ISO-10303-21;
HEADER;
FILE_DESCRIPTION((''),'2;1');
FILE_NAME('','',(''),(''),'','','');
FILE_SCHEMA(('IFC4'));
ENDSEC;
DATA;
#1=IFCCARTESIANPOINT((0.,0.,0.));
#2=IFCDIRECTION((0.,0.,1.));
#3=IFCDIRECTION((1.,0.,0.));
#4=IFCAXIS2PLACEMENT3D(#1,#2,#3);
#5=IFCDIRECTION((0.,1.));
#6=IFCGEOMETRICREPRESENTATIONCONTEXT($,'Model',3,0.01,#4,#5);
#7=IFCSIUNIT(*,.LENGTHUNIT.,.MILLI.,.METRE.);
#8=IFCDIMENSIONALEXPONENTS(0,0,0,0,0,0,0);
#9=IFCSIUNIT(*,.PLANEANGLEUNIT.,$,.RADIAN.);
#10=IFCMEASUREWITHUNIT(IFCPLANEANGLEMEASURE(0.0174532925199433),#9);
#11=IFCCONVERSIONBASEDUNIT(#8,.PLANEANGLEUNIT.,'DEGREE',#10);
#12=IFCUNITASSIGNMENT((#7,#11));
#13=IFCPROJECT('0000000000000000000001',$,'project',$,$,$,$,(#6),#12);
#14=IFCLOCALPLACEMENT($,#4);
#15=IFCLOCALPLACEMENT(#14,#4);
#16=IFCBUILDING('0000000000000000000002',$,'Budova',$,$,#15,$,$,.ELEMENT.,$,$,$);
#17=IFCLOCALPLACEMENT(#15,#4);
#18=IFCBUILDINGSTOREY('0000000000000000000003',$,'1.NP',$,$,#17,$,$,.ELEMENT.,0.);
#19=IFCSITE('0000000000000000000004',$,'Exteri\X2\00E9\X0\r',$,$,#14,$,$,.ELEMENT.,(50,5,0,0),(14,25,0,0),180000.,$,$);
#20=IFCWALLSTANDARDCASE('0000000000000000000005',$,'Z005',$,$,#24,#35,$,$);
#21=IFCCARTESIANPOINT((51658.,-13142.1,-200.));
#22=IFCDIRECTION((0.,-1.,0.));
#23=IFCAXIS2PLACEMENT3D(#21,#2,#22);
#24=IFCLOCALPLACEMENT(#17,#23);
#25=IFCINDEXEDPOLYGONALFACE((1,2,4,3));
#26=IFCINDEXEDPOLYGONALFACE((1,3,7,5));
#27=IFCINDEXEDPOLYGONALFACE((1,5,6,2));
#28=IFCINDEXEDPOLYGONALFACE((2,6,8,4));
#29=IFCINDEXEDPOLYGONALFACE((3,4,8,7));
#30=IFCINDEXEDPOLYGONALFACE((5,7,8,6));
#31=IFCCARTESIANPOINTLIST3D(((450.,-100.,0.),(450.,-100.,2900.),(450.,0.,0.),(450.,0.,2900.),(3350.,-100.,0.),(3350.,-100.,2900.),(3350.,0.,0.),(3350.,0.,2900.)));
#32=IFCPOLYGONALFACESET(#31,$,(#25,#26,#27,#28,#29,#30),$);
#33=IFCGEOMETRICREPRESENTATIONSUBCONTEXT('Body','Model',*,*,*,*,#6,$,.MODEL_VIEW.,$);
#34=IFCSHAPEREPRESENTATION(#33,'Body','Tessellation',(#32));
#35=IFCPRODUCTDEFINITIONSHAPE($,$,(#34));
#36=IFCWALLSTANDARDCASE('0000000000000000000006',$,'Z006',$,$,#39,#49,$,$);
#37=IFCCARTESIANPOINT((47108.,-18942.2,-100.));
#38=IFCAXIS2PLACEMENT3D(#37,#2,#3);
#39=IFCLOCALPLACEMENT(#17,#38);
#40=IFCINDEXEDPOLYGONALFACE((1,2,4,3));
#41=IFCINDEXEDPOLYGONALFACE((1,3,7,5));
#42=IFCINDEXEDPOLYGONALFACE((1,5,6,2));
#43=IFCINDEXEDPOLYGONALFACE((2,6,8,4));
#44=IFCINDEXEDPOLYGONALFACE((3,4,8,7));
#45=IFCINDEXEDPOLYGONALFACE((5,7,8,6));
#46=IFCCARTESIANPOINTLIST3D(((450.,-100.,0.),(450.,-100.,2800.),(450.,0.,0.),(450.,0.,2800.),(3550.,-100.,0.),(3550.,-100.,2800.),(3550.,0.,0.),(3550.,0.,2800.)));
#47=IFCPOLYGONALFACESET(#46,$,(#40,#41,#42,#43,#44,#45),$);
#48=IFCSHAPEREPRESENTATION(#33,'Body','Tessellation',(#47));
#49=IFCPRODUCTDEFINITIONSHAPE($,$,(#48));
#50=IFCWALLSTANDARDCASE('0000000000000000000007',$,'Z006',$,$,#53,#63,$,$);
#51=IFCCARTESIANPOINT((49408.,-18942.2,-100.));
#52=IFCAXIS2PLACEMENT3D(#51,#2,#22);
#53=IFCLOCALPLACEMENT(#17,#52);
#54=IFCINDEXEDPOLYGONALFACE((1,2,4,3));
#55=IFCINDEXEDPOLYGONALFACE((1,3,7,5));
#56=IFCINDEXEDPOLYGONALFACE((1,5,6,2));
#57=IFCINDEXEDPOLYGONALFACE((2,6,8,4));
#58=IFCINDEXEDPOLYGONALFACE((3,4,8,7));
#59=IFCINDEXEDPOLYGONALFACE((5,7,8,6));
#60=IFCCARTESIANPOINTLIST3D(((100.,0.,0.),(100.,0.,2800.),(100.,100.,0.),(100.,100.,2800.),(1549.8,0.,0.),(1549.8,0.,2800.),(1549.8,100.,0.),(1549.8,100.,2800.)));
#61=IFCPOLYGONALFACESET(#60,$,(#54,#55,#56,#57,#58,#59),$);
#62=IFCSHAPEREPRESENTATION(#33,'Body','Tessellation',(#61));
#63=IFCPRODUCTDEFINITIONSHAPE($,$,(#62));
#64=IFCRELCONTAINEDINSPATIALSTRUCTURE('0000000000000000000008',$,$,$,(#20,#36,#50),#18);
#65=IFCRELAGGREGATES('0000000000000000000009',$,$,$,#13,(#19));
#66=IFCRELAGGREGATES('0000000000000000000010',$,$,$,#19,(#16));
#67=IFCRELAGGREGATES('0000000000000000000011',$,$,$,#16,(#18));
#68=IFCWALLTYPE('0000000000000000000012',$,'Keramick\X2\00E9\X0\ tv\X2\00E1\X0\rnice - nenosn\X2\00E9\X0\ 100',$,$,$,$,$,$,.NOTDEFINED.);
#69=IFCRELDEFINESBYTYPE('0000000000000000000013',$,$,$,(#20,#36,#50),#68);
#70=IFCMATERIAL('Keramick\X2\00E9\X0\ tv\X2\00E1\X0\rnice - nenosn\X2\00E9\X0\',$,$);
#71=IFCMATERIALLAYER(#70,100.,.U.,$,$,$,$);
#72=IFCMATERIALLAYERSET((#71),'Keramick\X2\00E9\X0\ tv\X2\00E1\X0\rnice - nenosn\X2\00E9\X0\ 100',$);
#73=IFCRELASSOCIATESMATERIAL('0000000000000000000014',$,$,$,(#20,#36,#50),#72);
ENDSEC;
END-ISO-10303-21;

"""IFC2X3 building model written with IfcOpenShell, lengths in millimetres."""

from ifc_helpers import new_model, entity, si_unit, converted_unit, direction, frame, origin_with_axes, place, context, subcontext, project, spatial, polyline, outline, extrude, material, layer, layer_set, layer_usage, type_object, element, save


model = new_model("IFC2X3")

# Units and contexts
model_context = context("Model", 3, precision=0.01, world=origin_with_axes(), true_north=direction((0.0, 1.0)))
body_context = subcontext(model_context, "Body", "Model", "MODEL_VIEW")
ifc_project = project(units=[si_unit("LENGTHUNIT", "METRE", prefix="MILLI"), converted_unit("PLANEANGLEUNIT", "DEGREE", entity("IfcPlaneAngleMeasure", 0.0174532925199433), si_unit("PLANEANGLEUNIT", "RADIAN"), dimensions=[0, 0, 0, 0, 0, 0, 0])], contexts=[model_context])

# Site, building, storey
site_placement = place(None, origin_with_axes())
site = spatial("IfcSite", under=ifc_project, at=site_placement, Name="Exteriér", CompositionType="ELEMENT", RefLatitude=(50, 5, 0, 0), RefLongitude=(14, 25, 0, 0), RefElevation=180000.0)
building_placement = place(site_placement, origin_with_axes())
building = spatial("IfcBuilding", under=site, at=building_placement, Name="Budova", CompositionType="ELEMENT")
storey_placement = place(building_placement, origin_with_axes())
storey = spatial("IfcBuildingStorey", under=building, at=storey_placement, Name="1.NP", CompositionType="ELEMENT", Elevation=0.0)

# Wall
ifc_material_1 = material(Name="Keramické tvárnice - nenosné")
ifc_layer_1 = layer(ifc_material_1, 100.0, ventilated="UNKNOWN")
ifc_layer_set_1 = layer_set([ifc_layer_1], Name="Keramické tvárnice - nenosné 100")
ifc_layer_usage_1 = layer_usage(ifc_layer_set_1, "AXIS2", "NEGATIVE", 0.0)
wall_type_1 = type_object("IfcWallType", Name="Keramické tvárnice - nenosné 100", PredefinedType="NOTDEFINED")
wall_1_placement = place(storey_placement, frame((51658.0, -13142.1, -200.0), z_axis=(0.0, 0.0, 1.0), x_axis=(0.0, -1.0, 0.0)))
element("IfcWallStandardCase", 1, at=wall_1_placement, inside=storey, type_object=wall_type_1, material=ifc_layer_usage_1, Name="Z005", context=body_context, shape_type="SweptSolid", body=[
    extrude(outline(polyline([(450.0, -100.0), (3350.0, -100.0), (3350.0, 0.0), (450.0, 0.0), (450.0, -100.0)])), origin_with_axes(), (0.0, 0.0, 1.0), 2900.0),
])

# Walls
ifc_layer_usage_2 = layer_usage(ifc_layer_set_1, "AXIS2", "NEGATIVE", 0.0)
wall_2_placement = place(storey_placement, frame((47108.0, -18942.2, -100.0), z_axis=(0.0, 0.0, 1.0), x_axis=(1.0, 0.0, 0.0)))
element("IfcWallStandardCase", 2, at=wall_2_placement, inside=storey, type_object=wall_type_1, material=ifc_layer_usage_2, Name="Z006", context=body_context, shape_type="SweptSolid", body=[
    extrude(outline(polyline([(450.0, -100.0), (3550.0, -100.0), (3550.0, 0.0), (450.0, 0.0), (450.0, -100.0)])), origin_with_axes(), (0.0, 0.0, 1.0), 2800.0),
])
ifc_layer_usage_3 = layer_usage(ifc_layer_set_1, "AXIS2", "POSITIVE", 0.0)
wall_3_placement = place(storey_placement, frame((49408.0, -18942.2, -100.0), z_axis=(0.0, 0.0, 1.0), x_axis=(0.0, -1.0, 0.0)))
element("IfcWallStandardCase", 3, at=wall_3_placement, inside=storey, type_object=wall_type_1, material=ifc_layer_usage_3, Name="Z006", context=body_context, shape_type="SweptSolid", body=[
    extrude(outline(polyline([(100.0, 0.0), (1549.8, 0.0), (1549.8, 100.0), (100.0, 100.0), (100.0, 0.0)])), origin_with_axes(), (0.0, 0.0, 1.0), 2800.0),
])

save(model, "model.ifc")
